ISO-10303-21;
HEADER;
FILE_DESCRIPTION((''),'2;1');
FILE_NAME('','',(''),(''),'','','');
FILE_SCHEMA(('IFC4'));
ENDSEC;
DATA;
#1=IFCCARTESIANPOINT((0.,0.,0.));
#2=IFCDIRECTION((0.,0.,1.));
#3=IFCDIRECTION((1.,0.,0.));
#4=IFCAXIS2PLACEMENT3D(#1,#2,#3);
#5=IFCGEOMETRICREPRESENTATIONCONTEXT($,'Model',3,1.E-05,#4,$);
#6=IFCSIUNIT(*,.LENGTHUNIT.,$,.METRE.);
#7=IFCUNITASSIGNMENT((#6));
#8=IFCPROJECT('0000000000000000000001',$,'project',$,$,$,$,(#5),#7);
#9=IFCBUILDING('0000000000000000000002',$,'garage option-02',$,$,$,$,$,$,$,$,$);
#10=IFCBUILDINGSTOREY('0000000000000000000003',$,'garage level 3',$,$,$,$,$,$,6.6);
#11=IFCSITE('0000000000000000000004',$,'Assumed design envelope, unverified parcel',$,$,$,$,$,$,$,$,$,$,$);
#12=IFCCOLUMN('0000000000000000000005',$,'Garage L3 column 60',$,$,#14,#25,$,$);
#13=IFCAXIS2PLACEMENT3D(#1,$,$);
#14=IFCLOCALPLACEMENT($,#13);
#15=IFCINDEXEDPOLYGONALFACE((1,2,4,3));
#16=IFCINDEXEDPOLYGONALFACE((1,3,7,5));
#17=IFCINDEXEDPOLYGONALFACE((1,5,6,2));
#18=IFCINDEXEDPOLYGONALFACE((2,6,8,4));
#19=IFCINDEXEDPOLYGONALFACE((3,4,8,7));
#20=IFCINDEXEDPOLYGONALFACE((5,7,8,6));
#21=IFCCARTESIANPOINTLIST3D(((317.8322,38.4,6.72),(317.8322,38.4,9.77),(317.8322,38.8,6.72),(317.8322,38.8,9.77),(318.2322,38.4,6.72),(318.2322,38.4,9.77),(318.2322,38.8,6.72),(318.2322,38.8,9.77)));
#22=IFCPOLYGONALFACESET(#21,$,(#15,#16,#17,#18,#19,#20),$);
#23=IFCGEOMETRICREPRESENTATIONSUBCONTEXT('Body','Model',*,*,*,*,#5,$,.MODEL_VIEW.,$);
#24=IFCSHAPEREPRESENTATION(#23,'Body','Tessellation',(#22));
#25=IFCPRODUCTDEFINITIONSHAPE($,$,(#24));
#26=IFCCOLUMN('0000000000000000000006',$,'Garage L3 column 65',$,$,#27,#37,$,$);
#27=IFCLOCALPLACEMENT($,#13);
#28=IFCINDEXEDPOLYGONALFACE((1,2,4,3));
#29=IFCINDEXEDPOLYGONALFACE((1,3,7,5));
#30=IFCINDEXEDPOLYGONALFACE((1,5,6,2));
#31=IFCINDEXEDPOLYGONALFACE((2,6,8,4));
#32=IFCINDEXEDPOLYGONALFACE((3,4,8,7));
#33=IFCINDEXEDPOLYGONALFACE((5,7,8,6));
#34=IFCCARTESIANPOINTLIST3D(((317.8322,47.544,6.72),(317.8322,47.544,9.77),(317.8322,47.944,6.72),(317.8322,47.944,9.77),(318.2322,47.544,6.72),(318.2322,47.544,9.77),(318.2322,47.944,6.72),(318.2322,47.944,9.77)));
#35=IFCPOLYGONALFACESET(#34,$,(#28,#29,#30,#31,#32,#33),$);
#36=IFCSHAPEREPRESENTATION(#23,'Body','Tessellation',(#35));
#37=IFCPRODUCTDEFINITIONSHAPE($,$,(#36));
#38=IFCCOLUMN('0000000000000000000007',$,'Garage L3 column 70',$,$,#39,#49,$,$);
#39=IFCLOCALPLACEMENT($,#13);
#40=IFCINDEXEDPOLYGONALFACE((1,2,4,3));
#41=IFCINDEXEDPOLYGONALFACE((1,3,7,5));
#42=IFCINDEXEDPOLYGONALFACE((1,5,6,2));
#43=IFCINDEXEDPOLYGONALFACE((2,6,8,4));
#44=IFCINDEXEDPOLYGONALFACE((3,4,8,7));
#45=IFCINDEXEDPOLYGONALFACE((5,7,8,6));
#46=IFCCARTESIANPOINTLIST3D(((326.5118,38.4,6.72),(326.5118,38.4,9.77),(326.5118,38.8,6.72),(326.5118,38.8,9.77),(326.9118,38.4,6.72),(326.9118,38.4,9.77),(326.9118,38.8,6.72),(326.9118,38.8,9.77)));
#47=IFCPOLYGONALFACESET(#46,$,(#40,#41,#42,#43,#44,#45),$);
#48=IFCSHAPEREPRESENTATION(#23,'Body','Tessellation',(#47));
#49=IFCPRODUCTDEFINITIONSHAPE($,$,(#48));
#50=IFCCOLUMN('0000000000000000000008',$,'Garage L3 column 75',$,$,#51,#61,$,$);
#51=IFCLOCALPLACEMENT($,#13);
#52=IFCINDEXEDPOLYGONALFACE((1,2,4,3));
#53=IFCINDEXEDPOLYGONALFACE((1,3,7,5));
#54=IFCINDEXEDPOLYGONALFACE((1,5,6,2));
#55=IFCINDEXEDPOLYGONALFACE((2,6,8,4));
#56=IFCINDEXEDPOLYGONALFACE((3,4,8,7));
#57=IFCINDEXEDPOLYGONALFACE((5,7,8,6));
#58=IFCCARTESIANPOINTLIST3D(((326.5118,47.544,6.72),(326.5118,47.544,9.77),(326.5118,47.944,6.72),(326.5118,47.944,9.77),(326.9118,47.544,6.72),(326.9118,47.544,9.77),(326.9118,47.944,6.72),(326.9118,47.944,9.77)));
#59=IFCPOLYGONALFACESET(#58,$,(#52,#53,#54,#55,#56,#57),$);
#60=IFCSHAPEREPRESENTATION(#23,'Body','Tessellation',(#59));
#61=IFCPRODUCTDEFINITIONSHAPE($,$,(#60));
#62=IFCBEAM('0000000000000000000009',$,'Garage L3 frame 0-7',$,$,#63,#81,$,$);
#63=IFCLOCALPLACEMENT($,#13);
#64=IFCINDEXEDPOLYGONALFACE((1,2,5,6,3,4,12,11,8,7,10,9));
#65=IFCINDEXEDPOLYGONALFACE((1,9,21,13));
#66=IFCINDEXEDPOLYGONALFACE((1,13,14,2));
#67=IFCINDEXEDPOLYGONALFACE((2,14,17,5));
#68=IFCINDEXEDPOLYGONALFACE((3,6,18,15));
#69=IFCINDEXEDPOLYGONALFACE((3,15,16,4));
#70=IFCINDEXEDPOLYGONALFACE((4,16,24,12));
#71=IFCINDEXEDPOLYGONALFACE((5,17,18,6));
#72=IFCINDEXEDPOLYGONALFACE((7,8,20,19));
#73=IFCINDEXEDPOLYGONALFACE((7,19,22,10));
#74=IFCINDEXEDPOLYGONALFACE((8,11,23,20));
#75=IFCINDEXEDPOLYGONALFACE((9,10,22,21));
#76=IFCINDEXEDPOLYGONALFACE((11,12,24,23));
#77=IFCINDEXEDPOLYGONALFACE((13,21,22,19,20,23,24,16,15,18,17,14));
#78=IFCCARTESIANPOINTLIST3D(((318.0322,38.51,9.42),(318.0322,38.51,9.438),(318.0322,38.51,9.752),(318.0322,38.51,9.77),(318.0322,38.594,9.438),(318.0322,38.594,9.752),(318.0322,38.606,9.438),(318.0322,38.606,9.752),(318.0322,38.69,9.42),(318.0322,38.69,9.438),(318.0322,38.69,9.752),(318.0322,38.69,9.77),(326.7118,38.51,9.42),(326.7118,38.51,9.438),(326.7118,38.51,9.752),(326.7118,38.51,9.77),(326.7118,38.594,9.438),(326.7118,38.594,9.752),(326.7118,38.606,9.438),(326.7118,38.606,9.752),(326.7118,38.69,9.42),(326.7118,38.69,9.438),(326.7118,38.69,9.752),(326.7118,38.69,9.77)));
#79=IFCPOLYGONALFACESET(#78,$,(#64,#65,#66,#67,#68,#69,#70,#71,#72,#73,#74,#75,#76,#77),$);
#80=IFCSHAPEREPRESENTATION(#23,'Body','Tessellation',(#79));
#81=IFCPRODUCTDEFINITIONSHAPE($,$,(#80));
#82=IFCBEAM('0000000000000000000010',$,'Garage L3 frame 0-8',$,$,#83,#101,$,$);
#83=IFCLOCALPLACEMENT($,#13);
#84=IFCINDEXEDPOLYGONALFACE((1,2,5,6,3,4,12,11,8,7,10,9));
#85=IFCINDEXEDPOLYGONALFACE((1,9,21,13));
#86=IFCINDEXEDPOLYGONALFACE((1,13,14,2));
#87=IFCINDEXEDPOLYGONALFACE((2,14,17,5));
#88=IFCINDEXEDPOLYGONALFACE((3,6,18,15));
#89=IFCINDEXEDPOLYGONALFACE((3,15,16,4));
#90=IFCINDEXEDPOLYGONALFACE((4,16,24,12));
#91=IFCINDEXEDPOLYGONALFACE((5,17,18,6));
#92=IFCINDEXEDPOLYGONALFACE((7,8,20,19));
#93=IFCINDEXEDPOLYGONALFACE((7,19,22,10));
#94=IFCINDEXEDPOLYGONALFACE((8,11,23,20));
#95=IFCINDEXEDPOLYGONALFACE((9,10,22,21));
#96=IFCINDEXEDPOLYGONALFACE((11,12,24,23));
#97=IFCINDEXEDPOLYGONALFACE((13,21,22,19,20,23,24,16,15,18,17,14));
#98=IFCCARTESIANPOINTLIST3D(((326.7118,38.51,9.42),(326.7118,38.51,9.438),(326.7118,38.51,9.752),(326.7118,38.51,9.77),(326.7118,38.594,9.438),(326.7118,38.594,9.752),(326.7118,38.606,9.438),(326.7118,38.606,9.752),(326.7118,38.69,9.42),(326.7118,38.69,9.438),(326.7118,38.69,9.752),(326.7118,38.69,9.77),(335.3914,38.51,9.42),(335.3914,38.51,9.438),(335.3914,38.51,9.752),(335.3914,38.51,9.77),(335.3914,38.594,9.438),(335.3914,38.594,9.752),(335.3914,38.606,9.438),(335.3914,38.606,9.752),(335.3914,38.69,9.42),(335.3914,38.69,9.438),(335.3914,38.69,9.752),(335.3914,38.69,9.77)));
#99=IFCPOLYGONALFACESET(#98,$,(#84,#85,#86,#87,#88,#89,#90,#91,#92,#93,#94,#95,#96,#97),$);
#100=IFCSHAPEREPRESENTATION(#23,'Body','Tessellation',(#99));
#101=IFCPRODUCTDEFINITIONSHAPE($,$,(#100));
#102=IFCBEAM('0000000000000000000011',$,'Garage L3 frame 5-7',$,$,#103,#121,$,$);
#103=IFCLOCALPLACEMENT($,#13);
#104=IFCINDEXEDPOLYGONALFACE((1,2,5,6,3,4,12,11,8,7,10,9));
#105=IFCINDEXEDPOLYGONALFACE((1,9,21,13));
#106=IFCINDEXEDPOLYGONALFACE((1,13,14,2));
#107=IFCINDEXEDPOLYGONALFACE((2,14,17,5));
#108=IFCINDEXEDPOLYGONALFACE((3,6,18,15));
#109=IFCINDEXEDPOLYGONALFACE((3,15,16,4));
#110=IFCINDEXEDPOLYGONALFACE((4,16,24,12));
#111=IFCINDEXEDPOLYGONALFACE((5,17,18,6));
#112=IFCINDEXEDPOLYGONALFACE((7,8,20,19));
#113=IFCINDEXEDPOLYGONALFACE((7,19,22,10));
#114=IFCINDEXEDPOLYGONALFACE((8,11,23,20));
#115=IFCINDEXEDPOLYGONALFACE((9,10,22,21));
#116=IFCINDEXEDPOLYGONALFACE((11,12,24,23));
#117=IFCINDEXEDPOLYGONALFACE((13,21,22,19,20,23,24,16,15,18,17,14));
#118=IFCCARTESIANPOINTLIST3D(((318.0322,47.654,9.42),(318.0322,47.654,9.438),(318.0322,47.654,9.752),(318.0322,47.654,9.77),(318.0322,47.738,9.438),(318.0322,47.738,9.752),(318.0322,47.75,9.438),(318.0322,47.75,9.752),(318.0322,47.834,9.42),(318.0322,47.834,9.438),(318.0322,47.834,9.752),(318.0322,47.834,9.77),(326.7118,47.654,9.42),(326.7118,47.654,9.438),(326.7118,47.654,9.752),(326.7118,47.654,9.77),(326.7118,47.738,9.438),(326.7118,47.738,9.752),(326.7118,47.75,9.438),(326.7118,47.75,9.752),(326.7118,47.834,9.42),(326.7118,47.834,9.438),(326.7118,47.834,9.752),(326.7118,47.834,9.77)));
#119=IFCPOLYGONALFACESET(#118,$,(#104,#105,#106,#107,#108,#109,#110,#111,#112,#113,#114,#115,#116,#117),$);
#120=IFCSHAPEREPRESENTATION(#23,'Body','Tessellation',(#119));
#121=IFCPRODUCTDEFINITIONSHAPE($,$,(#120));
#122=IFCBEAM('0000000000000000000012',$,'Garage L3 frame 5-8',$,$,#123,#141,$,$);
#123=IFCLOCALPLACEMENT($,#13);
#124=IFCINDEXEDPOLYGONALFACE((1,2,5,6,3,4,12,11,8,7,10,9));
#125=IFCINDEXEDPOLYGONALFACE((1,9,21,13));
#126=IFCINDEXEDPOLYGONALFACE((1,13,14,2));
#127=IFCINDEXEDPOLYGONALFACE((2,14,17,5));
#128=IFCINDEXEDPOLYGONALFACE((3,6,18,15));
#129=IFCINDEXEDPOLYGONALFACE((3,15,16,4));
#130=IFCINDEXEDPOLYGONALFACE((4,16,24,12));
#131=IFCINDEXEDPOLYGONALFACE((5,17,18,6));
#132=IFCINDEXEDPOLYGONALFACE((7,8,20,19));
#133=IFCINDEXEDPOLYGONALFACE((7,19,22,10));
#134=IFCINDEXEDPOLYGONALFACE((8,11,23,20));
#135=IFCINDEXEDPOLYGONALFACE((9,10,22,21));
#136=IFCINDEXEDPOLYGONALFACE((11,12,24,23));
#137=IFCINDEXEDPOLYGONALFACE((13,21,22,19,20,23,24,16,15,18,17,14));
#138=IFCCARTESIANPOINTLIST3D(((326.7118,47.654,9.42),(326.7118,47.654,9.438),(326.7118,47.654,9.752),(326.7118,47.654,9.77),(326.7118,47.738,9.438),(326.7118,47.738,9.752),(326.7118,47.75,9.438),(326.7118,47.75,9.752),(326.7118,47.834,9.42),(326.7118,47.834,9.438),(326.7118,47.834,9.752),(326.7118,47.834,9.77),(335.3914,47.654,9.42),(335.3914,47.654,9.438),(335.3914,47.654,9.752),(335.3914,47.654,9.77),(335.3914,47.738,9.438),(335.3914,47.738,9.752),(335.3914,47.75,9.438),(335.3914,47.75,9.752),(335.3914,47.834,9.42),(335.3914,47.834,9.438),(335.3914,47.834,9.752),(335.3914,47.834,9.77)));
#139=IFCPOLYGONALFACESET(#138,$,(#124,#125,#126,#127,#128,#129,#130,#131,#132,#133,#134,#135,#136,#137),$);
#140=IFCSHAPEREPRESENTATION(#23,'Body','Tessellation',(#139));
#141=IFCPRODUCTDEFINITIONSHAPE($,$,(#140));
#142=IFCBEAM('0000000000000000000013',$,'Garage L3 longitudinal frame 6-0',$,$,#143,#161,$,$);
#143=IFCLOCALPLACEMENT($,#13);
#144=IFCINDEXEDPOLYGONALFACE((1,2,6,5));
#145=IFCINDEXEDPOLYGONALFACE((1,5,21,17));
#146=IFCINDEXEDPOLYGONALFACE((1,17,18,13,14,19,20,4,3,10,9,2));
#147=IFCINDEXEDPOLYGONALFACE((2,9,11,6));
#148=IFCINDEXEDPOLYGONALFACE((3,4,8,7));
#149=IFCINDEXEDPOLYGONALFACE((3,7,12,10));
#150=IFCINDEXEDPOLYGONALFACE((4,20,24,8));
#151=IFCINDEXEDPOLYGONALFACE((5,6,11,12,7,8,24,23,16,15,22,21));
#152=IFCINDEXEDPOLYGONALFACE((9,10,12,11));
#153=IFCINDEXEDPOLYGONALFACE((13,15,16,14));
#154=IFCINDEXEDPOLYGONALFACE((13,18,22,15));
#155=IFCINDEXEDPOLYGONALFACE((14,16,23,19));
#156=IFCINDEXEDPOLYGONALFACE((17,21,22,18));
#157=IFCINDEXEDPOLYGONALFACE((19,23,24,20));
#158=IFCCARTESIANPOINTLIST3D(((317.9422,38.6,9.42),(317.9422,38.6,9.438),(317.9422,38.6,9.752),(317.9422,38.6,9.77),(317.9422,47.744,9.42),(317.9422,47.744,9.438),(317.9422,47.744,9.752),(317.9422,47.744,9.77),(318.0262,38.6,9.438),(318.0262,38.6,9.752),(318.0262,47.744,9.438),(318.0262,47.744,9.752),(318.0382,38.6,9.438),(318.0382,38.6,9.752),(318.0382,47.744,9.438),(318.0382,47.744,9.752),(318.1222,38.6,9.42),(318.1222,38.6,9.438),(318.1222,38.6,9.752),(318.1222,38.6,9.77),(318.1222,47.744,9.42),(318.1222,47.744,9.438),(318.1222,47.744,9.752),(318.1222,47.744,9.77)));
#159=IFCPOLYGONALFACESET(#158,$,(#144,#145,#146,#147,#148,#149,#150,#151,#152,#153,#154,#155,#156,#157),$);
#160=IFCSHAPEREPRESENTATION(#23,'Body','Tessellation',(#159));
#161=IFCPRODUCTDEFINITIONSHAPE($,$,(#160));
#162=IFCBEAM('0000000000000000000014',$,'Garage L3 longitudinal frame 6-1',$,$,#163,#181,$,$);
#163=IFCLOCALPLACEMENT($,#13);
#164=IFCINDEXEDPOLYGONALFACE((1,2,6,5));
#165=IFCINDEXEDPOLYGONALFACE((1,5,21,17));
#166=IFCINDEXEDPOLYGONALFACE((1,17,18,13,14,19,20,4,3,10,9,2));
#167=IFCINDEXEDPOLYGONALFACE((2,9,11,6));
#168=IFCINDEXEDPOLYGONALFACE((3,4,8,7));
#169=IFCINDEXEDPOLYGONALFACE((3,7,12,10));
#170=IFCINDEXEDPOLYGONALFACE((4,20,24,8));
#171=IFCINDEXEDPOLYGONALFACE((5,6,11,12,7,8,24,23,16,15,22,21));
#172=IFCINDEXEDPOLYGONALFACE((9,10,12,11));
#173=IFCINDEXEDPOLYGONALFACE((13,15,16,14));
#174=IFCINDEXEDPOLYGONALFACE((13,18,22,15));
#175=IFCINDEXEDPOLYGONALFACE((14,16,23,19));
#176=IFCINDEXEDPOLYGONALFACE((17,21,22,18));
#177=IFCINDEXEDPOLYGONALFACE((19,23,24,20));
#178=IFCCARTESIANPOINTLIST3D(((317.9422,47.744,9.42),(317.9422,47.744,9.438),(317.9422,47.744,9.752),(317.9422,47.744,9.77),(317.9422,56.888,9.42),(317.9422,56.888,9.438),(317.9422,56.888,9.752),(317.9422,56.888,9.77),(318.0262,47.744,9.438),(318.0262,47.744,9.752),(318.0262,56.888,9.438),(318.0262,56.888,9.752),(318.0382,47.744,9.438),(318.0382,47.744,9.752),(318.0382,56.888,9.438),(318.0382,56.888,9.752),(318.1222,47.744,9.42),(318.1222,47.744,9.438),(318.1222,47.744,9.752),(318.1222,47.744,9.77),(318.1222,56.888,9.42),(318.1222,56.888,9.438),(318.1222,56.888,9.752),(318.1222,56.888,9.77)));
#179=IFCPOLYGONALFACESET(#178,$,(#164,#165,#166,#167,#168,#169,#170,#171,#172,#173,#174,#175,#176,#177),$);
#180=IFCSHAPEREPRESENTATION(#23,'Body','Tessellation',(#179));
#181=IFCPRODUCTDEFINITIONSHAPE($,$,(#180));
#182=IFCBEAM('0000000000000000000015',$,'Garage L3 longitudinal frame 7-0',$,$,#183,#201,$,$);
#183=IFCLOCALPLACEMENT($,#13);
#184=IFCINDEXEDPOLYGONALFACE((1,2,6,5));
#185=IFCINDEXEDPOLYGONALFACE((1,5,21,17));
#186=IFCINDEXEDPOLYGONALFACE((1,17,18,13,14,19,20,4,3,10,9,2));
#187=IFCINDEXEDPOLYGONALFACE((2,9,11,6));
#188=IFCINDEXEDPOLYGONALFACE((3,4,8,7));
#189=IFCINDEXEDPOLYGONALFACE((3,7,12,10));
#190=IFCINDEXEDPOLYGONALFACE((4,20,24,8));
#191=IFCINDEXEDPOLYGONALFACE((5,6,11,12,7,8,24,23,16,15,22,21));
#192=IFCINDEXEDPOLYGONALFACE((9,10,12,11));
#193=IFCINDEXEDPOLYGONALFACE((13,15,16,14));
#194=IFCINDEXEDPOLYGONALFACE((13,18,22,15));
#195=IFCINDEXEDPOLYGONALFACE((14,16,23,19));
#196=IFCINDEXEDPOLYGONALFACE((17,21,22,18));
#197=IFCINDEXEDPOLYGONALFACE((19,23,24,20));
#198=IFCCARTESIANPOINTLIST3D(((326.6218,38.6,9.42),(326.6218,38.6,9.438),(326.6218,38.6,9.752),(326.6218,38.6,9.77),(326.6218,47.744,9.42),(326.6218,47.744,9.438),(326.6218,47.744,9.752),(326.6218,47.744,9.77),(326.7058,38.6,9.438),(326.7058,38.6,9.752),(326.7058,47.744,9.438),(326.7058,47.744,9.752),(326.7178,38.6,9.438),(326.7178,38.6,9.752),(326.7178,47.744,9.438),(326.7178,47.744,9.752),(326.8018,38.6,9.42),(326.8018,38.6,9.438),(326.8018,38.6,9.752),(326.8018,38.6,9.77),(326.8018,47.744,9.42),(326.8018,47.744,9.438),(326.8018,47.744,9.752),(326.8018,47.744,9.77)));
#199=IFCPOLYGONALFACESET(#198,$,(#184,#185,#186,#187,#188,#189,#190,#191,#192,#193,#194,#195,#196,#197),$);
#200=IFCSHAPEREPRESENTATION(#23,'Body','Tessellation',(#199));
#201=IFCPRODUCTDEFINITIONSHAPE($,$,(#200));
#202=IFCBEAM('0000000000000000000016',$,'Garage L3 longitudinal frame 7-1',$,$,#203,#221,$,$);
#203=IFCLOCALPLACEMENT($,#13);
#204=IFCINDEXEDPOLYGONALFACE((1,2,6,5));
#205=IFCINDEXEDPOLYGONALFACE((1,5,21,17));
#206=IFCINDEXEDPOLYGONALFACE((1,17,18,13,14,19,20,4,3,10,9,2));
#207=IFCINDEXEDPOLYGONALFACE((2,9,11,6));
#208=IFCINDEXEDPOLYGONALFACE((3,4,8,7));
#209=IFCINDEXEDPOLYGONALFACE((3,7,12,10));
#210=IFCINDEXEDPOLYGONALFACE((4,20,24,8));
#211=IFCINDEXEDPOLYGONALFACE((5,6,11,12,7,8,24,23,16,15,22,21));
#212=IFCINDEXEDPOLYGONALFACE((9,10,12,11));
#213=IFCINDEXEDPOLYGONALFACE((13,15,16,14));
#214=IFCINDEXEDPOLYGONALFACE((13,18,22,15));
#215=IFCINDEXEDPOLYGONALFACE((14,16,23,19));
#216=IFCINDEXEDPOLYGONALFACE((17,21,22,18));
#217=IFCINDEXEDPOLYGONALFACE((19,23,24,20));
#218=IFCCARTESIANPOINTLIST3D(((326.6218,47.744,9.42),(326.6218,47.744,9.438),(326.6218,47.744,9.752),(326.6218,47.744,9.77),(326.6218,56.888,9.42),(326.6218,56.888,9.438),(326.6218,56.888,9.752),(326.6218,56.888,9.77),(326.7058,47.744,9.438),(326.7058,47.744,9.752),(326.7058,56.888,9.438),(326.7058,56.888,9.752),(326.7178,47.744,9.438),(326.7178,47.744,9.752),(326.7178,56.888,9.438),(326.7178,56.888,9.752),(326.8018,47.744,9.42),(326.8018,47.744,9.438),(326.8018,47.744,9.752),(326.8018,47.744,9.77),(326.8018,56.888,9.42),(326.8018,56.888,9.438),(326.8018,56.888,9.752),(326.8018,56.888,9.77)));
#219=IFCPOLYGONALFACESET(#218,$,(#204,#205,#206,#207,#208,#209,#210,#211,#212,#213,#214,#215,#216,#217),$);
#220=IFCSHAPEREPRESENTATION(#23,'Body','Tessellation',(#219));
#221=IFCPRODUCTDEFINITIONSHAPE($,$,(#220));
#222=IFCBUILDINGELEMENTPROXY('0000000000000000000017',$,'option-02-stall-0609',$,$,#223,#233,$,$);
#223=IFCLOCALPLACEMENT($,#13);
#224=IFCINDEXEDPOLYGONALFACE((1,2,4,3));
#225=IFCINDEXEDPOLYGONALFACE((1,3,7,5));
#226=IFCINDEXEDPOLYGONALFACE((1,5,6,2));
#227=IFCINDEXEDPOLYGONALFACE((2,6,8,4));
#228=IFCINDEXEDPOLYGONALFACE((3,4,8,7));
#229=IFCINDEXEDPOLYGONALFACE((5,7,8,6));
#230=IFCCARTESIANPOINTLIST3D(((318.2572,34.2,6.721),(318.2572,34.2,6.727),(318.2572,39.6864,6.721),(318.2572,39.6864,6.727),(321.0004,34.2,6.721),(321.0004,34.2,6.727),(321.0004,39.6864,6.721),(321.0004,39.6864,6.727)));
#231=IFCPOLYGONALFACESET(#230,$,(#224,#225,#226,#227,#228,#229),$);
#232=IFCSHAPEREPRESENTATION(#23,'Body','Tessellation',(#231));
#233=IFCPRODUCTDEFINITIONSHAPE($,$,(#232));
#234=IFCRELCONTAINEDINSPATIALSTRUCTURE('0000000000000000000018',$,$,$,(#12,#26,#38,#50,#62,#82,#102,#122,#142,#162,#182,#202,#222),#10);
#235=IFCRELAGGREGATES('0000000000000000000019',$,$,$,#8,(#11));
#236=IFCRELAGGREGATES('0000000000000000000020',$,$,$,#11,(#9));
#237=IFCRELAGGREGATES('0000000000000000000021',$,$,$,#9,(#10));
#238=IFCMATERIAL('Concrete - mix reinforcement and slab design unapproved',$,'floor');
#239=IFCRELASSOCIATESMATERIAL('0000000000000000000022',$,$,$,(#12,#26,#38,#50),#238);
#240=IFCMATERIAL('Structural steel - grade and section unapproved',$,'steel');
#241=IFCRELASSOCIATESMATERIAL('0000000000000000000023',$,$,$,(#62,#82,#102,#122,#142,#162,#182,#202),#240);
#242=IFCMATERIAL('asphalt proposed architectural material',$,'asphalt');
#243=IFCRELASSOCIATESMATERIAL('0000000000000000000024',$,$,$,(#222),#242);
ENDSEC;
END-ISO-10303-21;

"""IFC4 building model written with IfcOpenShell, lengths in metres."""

from ifc_helpers import new_model, si_unit, frame, origin_with_axes, place, context, subcontext, project, spatial, rectangle, i_section, extrude, material, element, save


model = new_model("IFC4")

# Units and contexts
model_context = context("Model", 3, precision=1e-05, world=origin_with_axes())
body_context = subcontext(model_context, "Body", "Model", "MODEL_VIEW")
ifc_project = project(units=[si_unit("LENGTHUNIT", "METRE")], contexts=[model_context])

# Site, building, storey
site = spatial("IfcSite", under=ifc_project, Name="Assumed design envelope, unverified parcel")
building = spatial("IfcBuilding", under=site, Name="garage option-02")
storey = spatial("IfcBuildingStorey", under=building, Name="garage level 3", Elevation=6.6)

# Columns
ifc_material_1 = material(Name="Concrete - mix reinforcement and slab design unapproved", Category="floor")
for number, where, z_axis, x_axis, name in (
    (1, (318.0322, 38.6, 6.72), (0.0, 0.0, 1.0), (1.0, 0.0, 0.0), "Garage L3 column 60"),
    (2, (318.0322, 47.744, 6.72), (0.0, 0.0, 1.0), (1.0, 0.0, 0.0), "Garage L3 column 65"),
    (3, (326.7118, 38.6, 6.72), (0.0, 0.0, 1.0), (1.0, 0.0, 0.0), "Garage L3 column 70"),
    (4, (326.7118, 47.744, 6.72), (0.0, 0.0, 1.0), (1.0, 0.0, 0.0), "Garage L3 column 75"),
):
    element("IfcColumn", number, at=place(None, frame(where, z_axis=z_axis, x_axis=x_axis)), inside=storey, material=ifc_material_1, Name=name, context=body_context, shape_type="SweptSolid", body=[
        extrude(rectangle(XDim=0.4, YDim=0.4), origin_with_axes(), (0.0, 0.0, 1.0), 3.05),
    ])

# Beams
ifc_material_2 = material(Name="Structural steel - grade and section unapproved", Category="steel")
for number, where, z_axis, x_axis, name in (
    (5, (318.0322, 38.6, 9.595), (1.0, 0.0, 0.0), (0.0, 1.0, 0.0), "Garage L3 frame 0-7"),
    (6, (326.7118, 38.6, 9.595), (1.0, 0.0, 0.0), (0.0, 1.0, 0.0), "Garage L3 frame 0-8"),
    (7, (318.0322, 47.744, 9.595), (1.0, 0.0, 0.0), (0.0, 1.0, 0.0), "Garage L3 frame 5-7"),
    (8, (326.7118, 47.744, 9.595), (1.0, 0.0, 0.0), (0.0, 1.0, 0.0), "Garage L3 frame 5-8"),
):
    element("IfcBeam", number, at=place(None, frame(where, z_axis=z_axis, x_axis=x_axis)), inside=storey, material=ifc_material_2, Name=name, context=body_context, shape_type="SweptSolid", body=[
        extrude(i_section(OverallWidth=0.18, OverallDepth=0.35, WebThickness=0.012, FlangeThickness=0.018, FilletRadius=0.0), origin_with_axes(), (0.0, 0.0, 1.0), 8.6796),
    ])
for number, where, z_axis, x_axis, name in (
    (9, (318.0322, 38.6, 9.595), (0.0, 1.0, 0.0), (-1.0, 0.0, 0.0), "Garage L3 longitudinal frame 6-0"),
    (10, (318.0322, 47.744, 9.595), (0.0, 1.0, 0.0), (-1.0, 0.0, 0.0), "Garage L3 longitudinal frame 6-1"),
    (11, (326.7118, 38.6, 9.595), (0.0, 1.0, 0.0), (-1.0, 0.0, 0.0), "Garage L3 longitudinal frame 7-0"),
    (12, (326.7118, 47.744, 9.595), (0.0, 1.0, 0.0), (-1.0, 0.0, 0.0), "Garage L3 longitudinal frame 7-1"),
):
    element("IfcBeam", number, at=place(None, frame(where, z_axis=z_axis, x_axis=x_axis)), inside=storey, material=ifc_material_2, Name=name, context=body_context, shape_type="SweptSolid", body=[
        extrude(i_section(OverallWidth=0.18, OverallDepth=0.35, WebThickness=0.012, FlangeThickness=0.018, FilletRadius=0.0), origin_with_axes(), (0.0, 0.0, 1.0), 9.144),
    ])

# Building element proxy
ifc_material_3 = material(Name="asphalt proposed architectural material", Category="asphalt")
for number, where, z_axis, x_axis, name in (
    (13, (319.6288, 36.9432, 6.721), (0.0, 0.0, 1.0), (1.0, 0.0, 0.0), "option-02-stall-0609"),
):
    element("IfcBuildingElementProxy", number, at=place(None, frame(where, z_axis=z_axis, x_axis=x_axis)), inside=storey, material=ifc_material_3, Name=name, context=body_context, shape_type="SweptSolid", body=[
        extrude(rectangle(XDim=2.7432, YDim=5.4864), origin_with_axes(), (0.0, 0.0, 1.0), 0.006),
    ])

save(model, "model.ifc")
